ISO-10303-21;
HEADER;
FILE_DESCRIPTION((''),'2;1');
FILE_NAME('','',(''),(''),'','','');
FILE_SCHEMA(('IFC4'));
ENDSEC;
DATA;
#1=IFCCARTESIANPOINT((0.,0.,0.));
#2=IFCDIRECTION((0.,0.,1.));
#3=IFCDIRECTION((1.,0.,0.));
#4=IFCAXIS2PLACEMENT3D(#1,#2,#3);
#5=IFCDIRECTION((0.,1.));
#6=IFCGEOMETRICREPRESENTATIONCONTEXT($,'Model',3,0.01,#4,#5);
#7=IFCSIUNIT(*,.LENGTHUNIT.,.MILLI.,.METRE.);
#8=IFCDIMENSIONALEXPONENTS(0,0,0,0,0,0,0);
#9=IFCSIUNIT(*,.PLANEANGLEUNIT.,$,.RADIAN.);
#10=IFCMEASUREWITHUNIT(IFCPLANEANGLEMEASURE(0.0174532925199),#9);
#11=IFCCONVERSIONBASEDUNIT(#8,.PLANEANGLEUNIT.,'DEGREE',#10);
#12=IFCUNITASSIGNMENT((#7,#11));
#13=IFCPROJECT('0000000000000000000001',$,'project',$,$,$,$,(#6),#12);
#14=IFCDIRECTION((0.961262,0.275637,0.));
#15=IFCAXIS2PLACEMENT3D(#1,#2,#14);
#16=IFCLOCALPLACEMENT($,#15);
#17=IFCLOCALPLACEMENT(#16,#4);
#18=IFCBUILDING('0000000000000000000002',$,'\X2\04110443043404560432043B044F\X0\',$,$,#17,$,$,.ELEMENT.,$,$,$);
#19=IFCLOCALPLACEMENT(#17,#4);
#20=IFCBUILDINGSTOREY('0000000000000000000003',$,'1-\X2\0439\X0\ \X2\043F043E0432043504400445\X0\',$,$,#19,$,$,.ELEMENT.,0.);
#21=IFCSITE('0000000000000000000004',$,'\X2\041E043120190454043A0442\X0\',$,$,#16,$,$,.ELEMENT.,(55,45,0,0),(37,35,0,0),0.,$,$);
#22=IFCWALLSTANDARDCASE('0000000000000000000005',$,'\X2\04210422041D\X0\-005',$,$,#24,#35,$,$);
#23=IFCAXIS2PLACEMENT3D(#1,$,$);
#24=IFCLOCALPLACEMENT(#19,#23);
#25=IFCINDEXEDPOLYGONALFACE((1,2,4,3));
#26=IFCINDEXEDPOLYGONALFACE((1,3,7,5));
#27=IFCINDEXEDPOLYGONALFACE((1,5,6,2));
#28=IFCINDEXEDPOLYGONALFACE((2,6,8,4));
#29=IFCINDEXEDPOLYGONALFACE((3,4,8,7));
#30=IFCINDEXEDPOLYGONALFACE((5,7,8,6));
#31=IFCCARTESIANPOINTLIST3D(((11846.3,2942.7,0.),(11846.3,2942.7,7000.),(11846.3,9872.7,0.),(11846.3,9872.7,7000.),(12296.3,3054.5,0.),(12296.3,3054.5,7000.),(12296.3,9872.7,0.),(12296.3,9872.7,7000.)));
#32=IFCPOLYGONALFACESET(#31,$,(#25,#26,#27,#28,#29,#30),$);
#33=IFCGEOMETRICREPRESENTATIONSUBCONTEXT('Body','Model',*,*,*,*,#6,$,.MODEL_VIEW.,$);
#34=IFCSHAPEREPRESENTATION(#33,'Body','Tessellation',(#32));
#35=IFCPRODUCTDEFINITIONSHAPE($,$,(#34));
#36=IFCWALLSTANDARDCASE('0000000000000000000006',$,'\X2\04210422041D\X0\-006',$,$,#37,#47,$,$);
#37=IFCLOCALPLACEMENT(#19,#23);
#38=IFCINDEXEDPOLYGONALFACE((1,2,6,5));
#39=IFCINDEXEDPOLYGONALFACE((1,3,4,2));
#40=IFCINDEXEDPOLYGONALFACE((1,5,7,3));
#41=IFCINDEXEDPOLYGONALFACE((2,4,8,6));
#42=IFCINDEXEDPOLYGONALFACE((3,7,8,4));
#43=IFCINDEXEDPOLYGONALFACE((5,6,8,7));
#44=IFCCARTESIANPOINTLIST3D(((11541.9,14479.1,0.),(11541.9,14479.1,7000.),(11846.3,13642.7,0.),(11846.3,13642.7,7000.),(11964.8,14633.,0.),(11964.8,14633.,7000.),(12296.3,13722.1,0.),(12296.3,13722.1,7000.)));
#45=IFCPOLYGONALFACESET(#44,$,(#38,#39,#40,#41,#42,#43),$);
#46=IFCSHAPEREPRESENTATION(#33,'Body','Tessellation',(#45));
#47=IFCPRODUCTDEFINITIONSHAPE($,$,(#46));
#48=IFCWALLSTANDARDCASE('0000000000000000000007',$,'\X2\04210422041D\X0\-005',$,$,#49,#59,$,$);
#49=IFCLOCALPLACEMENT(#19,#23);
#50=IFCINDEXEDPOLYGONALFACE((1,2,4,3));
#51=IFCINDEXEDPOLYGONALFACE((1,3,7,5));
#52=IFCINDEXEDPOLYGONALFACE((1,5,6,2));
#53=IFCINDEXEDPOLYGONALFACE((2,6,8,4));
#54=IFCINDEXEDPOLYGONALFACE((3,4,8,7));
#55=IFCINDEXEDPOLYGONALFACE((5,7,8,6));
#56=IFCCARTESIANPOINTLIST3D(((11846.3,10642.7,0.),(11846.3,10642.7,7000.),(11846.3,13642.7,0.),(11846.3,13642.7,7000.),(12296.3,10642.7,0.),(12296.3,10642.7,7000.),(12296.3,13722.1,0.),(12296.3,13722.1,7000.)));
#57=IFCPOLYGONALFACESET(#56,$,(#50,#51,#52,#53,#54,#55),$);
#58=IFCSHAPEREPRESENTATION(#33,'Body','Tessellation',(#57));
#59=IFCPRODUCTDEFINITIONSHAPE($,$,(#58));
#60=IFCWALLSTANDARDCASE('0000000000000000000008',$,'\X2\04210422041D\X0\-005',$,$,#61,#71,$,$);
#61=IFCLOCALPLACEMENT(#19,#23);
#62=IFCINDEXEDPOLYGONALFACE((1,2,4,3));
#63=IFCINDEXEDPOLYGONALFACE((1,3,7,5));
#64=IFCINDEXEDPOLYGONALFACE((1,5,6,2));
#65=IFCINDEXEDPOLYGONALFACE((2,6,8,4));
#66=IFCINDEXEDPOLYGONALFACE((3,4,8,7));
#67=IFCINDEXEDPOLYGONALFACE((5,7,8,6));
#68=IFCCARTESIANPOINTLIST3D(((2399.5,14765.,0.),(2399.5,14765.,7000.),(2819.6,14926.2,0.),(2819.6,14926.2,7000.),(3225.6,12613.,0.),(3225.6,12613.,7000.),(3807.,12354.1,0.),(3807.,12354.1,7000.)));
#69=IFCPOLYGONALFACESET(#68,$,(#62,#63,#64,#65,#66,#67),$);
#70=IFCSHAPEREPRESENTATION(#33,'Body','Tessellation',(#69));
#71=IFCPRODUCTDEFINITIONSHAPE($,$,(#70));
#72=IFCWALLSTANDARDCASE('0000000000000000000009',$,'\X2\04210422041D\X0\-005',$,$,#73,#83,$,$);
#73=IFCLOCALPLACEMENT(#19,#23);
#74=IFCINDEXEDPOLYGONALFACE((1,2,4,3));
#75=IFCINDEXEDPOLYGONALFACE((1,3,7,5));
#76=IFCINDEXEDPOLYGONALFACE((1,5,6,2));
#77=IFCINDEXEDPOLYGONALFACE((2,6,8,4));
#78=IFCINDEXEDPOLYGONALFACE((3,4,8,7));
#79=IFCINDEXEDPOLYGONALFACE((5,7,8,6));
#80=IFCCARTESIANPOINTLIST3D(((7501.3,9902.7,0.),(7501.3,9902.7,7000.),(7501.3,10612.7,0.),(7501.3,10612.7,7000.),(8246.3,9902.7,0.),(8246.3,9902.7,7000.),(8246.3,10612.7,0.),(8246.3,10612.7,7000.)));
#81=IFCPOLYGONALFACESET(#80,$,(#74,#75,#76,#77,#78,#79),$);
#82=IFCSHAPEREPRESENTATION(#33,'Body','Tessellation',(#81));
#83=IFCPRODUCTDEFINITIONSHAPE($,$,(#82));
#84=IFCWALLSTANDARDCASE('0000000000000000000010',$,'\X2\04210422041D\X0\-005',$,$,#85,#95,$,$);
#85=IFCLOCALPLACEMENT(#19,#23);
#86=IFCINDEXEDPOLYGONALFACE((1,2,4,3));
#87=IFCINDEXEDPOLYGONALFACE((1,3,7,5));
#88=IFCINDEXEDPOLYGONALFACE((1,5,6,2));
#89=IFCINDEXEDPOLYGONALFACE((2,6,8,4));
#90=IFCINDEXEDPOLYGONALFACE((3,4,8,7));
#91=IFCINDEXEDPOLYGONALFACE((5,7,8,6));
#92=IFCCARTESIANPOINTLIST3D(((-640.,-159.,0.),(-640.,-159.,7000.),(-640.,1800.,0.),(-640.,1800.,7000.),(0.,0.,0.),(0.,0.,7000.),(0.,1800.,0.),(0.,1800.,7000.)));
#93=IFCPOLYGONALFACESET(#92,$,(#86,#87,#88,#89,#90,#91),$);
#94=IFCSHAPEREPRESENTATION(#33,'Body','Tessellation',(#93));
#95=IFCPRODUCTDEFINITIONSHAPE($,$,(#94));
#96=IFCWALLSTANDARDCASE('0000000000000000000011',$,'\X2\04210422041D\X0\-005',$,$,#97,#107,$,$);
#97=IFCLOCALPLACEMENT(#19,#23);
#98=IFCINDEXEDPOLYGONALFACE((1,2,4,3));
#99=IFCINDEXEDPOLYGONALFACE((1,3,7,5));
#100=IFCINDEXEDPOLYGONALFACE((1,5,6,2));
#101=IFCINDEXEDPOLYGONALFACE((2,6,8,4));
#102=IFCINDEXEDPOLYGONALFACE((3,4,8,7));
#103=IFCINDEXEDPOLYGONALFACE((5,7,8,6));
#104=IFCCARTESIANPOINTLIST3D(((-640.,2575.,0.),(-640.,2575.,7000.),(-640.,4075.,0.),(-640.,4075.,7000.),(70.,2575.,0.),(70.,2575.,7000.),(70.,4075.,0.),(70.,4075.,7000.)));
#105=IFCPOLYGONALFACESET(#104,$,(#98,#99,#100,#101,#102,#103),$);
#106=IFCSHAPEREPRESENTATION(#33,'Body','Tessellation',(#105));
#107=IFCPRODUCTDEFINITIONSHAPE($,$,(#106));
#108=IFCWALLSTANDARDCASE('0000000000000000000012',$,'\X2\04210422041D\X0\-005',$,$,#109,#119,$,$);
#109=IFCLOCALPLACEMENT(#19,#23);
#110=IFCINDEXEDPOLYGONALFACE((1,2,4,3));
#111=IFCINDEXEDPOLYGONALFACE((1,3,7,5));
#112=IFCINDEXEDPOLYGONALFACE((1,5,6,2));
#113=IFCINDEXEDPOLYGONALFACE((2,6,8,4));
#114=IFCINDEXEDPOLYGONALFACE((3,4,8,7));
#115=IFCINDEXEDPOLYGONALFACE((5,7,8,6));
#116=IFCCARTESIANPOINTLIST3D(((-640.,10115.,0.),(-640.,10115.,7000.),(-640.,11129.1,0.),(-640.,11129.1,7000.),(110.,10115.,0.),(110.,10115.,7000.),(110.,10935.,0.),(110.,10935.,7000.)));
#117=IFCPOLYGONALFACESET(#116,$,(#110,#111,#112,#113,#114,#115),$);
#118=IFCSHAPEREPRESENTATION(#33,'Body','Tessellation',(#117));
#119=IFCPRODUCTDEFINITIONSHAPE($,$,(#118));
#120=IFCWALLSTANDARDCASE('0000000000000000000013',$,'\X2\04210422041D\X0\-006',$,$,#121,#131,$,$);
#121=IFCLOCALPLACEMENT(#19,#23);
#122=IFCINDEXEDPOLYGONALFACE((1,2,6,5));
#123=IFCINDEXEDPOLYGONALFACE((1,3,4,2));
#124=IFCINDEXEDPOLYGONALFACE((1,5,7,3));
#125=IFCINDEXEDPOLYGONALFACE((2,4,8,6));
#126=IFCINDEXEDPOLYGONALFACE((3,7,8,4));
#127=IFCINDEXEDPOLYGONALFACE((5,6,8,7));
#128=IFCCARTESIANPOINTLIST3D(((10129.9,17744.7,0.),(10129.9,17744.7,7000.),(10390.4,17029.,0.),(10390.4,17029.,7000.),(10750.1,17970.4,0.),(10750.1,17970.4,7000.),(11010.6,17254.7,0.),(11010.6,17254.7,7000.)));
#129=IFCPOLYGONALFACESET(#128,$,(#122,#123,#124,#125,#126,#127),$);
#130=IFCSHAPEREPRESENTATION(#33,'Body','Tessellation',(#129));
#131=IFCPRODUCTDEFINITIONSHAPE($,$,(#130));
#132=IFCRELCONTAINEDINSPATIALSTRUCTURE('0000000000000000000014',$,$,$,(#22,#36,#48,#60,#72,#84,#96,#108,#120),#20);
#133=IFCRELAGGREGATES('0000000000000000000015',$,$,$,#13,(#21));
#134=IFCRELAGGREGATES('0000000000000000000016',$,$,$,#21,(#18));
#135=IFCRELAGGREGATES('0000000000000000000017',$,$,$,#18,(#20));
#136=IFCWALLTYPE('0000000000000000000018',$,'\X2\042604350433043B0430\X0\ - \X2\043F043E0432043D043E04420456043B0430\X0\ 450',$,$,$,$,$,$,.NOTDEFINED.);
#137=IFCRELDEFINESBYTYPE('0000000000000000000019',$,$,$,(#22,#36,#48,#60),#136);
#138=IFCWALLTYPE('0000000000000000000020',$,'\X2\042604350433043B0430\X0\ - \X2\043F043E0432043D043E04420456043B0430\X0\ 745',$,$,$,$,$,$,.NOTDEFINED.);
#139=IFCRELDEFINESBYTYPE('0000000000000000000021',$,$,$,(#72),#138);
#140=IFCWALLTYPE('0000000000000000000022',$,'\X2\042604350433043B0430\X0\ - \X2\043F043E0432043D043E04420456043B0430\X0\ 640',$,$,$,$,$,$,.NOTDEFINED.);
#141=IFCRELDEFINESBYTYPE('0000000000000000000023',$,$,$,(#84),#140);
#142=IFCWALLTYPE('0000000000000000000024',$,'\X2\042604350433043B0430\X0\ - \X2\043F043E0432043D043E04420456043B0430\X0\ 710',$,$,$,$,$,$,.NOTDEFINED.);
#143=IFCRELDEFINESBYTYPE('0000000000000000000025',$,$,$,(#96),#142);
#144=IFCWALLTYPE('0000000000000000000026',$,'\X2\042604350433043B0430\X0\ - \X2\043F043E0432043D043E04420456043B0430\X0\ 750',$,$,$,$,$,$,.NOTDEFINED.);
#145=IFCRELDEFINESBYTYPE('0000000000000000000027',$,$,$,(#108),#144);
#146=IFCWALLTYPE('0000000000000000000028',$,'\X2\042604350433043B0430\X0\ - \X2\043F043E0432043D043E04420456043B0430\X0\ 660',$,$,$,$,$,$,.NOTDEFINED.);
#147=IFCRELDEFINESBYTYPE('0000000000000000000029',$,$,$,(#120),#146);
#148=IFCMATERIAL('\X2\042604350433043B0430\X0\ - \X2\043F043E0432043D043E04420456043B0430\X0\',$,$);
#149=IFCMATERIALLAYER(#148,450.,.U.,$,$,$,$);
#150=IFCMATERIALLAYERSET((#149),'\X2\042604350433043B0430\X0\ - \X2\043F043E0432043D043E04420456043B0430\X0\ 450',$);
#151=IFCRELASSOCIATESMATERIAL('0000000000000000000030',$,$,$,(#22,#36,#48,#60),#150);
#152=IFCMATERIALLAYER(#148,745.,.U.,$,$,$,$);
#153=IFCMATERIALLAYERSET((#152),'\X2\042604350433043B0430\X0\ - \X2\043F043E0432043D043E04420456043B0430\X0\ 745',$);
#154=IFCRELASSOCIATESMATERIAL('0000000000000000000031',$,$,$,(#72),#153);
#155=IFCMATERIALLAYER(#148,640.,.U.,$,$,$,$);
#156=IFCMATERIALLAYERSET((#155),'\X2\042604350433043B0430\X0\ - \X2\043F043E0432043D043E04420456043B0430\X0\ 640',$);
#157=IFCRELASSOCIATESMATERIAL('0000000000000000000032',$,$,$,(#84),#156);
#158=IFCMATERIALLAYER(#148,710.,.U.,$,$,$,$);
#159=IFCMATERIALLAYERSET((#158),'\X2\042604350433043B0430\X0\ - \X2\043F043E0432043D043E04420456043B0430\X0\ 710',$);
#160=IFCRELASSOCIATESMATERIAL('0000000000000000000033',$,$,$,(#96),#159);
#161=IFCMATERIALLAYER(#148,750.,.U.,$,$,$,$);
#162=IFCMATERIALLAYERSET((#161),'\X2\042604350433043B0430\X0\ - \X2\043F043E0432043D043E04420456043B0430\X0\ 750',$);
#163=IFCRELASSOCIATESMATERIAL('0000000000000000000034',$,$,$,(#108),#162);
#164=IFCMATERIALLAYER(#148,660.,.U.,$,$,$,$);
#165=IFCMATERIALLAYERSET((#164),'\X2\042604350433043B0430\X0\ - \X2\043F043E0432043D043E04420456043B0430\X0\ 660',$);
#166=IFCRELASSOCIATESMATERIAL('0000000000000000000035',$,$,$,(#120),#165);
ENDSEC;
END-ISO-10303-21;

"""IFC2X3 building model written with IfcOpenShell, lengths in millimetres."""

from ifc_helpers import new_model, entity, si_unit, converted_unit, direction, frame, origin_with_axes, place, context, subcontext, project, spatial, polyline, outline, extrude, material, layer, layer_set, layer_usage, type_object, element, save


model = new_model("IFC2X3")

# Units and contexts
model_context = context("Model", 3, precision=0.01, world=origin_with_axes(), true_north=direction((0.0, 1.0)))
body_context = subcontext(model_context, "Body", "Model", "MODEL_VIEW")
ifc_project = project(units=[si_unit("LENGTHUNIT", "METRE", prefix="MILLI"), converted_unit("PLANEANGLEUNIT", "DEGREE", entity("IfcPlaneAngleMeasure", 0.0174532925199), si_unit("PLANEANGLEUNIT", "RADIAN"), dimensions=[0, 0, 0, 0, 0, 0, 0])], contexts=[model_context])

# Site, building, storey
site_placement = place(None, frame((0.0, 0.0, 0.0), z_axis=(0.0, 0.0, 1.0), x_axis=(0.961262, 0.275637, 0.0)))
site = spatial("IfcSite", under=ifc_project, at=site_placement, Name="Об’єкт", CompositionType="ELEMENT", RefLatitude=(55, 45, 0, 0), RefLongitude=(37, 35, 0, 0), RefElevation=0.0)
building_placement = place(site_placement, origin_with_axes())
building = spatial("IfcBuilding", under=site, at=building_placement, Name="Будівля", CompositionType="ELEMENT")
storey_placement = place(building_placement, origin_with_axes())
storey = spatial("IfcBuildingStorey", under=building, at=storey_placement, Name="1-й поверх", CompositionType="ELEMENT", Elevation=0.0)

# Walls
ifc_material_1 = material(Name="Цегла - повнотіла")
ifc_layer_1 = layer(ifc_material_1, 450.0, ventilated="UNKNOWN")
ifc_layer_set_1 = layer_set([ifc_layer_1], Name="Цегла - повнотіла 450")
ifc_layer_usage_1 = layer_usage(ifc_layer_set_1, "AXIS2", "POSITIVE", 0.0)
wall_type_1 = type_object("IfcWallType", Name="Цегла - повнотіла 450", PredefinedType="NOTDEFINED")
wall_1_placement = place(storey_placement, frame((12296.3, 3054.5, 0.0), z_axis=(0.0, 0.0, 1.0), x_axis=(0.0, 1.0, 0.0)))
element("IfcWallStandardCase", 1, at=wall_1_placement, inside=storey, type_object=wall_type_1, material=ifc_layer_usage_1, Name="СТН-005", context=body_context, shape_type="SweptSolid", body=[
    extrude(outline(polyline([(0.0, 0.0), (6818.2, 0.0), (6818.2, 450.0), (-111.8, 450.0), (0.0, 0.0)])), origin_with_axes(), (0.0, 0.0, 1.0), 7000.0),
])
ifc_layer_usage_2 = layer_usage(ifc_layer_set_1, "AXIS2", "POSITIVE", 0.0)
wall_2_placement = place(storey_placement, frame((12296.3, 13722.1, 0.0), z_axis=(0.0, 0.0, 1.0), x_axis=(-0.34202, 0.939693, 0.0)))
element("IfcWallStandardCase", 2, at=wall_2_placement, inside=storey, type_object=wall_type_1, material=ifc_layer_usage_2, Name="СТН-006", context=body_context, shape_type="SweptSolid", body=[
    extrude(outline(polyline([(0.0, 0.0), (969.3, 0.0), (969.3, 450.0), (79.3, 450.0), (0.0, 0.0)])), origin_with_axes(), (0.0, 0.0, 1.0), 7000.0),
])
ifc_layer_usage_3 = layer_usage(ifc_layer_set_1, "AXIS2", "POSITIVE", 0.0)
wall_3_placement = place(storey_placement, frame((12296.3, 10642.7, 0.0), z_axis=(0.0, 0.0, 1.0), x_axis=(0.0, 1.0, 0.0)))
element("IfcWallStandardCase", 3, at=wall_3_placement, inside=storey, type_object=wall_type_1, material=ifc_layer_usage_3, Name="СТН-005", context=body_context, shape_type="SweptSolid", body=[
    extrude(outline(polyline([(0.0, 0.0), (3079.3, 0.0), (3000.0, 450.0), (0.0, 450.0), (0.0, 0.0)])), origin_with_axes(), (0.0, 0.0, 1.0), 7000.0),
])
ifc_layer_usage_4 = layer_usage(ifc_layer_set_1, "AXIS2", "POSITIVE", 0.0)
wall_4_placement = place(storey_placement, frame((3645.7, 12774.2, 0.0), z_axis=(0.0, 0.0, 1.0), x_axis=(-0.358368, 0.93358, 0.0)))
element("IfcWallStandardCase", 4, at=wall_4_placement, inside=storey, type_object=wall_type_1, material=ifc_layer_usage_4, Name="СТН-005", context=body_context, shape_type="SweptSolid", body=[
    extrude(outline(polyline([(-450.0, 0.0), (2305.1, 0.0), (2305.1, 450.0), (0.0, 450.0), (-450.0, 0.0)])), origin_with_axes(), (0.0, 0.0, 1.0), 7000.0),
])
ifc_layer_2 = layer(ifc_material_1, 745.0, ventilated="UNKNOWN")
ifc_layer_set_2 = layer_set([ifc_layer_2], Name="Цегла - повнотіла 745")
ifc_layer_usage_5 = layer_usage(ifc_layer_set_2, "AXIS2", "POSITIVE", -745.0)
wall_type_2 = type_object("IfcWallType", Name="Цегла - повнотіла 745", PredefinedType="NOTDEFINED")
wall_5_placement = place(storey_placement, frame((8246.3, 10612.7, 0.0), z_axis=(0.0, 0.0, 1.0), x_axis=(0.0, -1.0, 0.0)))
element("IfcWallStandardCase", 5, at=wall_5_placement, inside=storey, type_object=wall_type_2, material=ifc_layer_usage_5, Name="СТН-005", context=body_context, shape_type="SweptSolid", body=[
    extrude(outline(polyline([(0.0, -745.0), (710.0, -745.0), (710.0, 0.0), (0.0, 0.0), (0.0, -745.0)])), origin_with_axes(), (0.0, 0.0, 1.0), 7000.0),
])
ifc_layer_3 = layer(ifc_material_1, 640.0, ventilated="UNKNOWN")
ifc_layer_set_3 = layer_set([ifc_layer_3], Name="Цегла - повнотіла 640")
ifc_layer_usage_6 = layer_usage(ifc_layer_set_3, "AXIS2", "POSITIVE", 0.0)
wall_type_3 = type_object("IfcWallType", Name="Цегла - повнотіла 640", PredefinedType="NOTDEFINED")
wall_6_placement = place(storey_placement, frame((-640.0, 1800.0, 0.0), z_axis=(0.0, 0.0, 1.0), x_axis=(0.0, -1.0, 0.0)))
element("IfcWallStandardCase", 6, at=wall_6_placement, inside=storey, type_object=wall_type_3, material=ifc_layer_usage_6, Name="СТН-005", context=body_context, shape_type="SweptSolid", body=[
    extrude(outline(polyline([(0.0, 0.0), (1959.0, 0.0), (1800.0, 640.0), (0.0, 640.0), (0.0, 0.0)])), origin_with_axes(), (0.0, 0.0, 1.0), 7000.0),
])
ifc_layer_4 = layer(ifc_material_1, 710.0, ventilated="UNKNOWN")
ifc_layer_set_4 = layer_set([ifc_layer_4], Name="Цегла - повнотіла 710")
ifc_layer_usage_7 = layer_usage(ifc_layer_set_4, "AXIS2", "POSITIVE", -710.0)
wall_type_4 = type_object("IfcWallType", Name="Цегла - повнотіла 710", PredefinedType="NOTDEFINED")
wall_7_placement = place(storey_placement, frame((-640.0, 2575.0, 0.0), z_axis=(0.0, 0.0, 1.0), x_axis=(0.0, 1.0, 0.0)))
element("IfcWallStandardCase", 7, at=wall_7_placement, inside=storey, type_object=wall_type_4, material=ifc_layer_usage_7, Name="СТН-005", context=body_context, shape_type="SweptSolid", body=[
    extrude(outline(polyline([(0.0, -710.0), (1500.0, -710.0), (1500.0, 0.0), (0.0, 0.0), (0.0, -710.0)])), origin_with_axes(), (0.0, 0.0, 1.0), 7000.0),
])
ifc_layer_5 = layer(ifc_material_1, 750.0, ventilated="UNKNOWN")
ifc_layer_set_5 = layer_set([ifc_layer_5], Name="Цегла - повнотіла 750")
ifc_layer_usage_8 = layer_usage(ifc_layer_set_5, "AXIS2", "POSITIVE", -750.0)
wall_type_5 = type_object("IfcWallType", Name="Цегла - повнотіла 750", PredefinedType="NOTDEFINED")
wall_8_placement = place(storey_placement, frame((-640.0, 10115.0, 0.0), z_axis=(0.0, 0.0, 1.0), x_axis=(0.0, 1.0, 0.0)))
element("IfcWallStandardCase", 8, at=wall_8_placement, inside=storey, type_object=wall_type_5, material=ifc_layer_usage_8, Name="СТН-005", context=body_context, shape_type="SweptSolid", body=[
    extrude(outline(polyline([(0.0, -750.0), (820.0, -750.0), (1014.1, 0.0), (0.0, 0.0), (0.0, -750.0)])), origin_with_axes(), (0.0, 0.0, 1.0), 7000.0),
])
ifc_layer_6 = layer(ifc_material_1, 660.0, ventilated="UNKNOWN")
ifc_layer_set_6 = layer_set([ifc_layer_6], Name="Цегла - повнотіла 660")
ifc_layer_usage_9 = layer_usage(ifc_layer_set_6, "AXIS2", "POSITIVE", 0.0)
wall_type_6 = type_object("IfcWallType", Name="Цегла - повнотіла 660", PredefinedType="NOTDEFINED")
wall_9_placement = place(storey_placement, frame((11010.6, 17254.7, 0.0), z_axis=(0.0, 0.0, 1.0), x_axis=(-0.34202, 0.939693, 0.0)))
element("IfcWallStandardCase", 9, at=wall_9_placement, inside=storey, type_object=wall_type_6, material=ifc_layer_usage_9, Name="СТН-006", context=body_context, shape_type="SweptSolid", body=[
    extrude(outline(polyline([(0.0, 0.0), (761.6, 0.0), (761.6, 660.0), (0.0, 660.0), (0.0, 0.0)])), origin_with_axes(), (0.0, 0.0, 1.0), 7000.0),
])

save(model, "model.ifc")
